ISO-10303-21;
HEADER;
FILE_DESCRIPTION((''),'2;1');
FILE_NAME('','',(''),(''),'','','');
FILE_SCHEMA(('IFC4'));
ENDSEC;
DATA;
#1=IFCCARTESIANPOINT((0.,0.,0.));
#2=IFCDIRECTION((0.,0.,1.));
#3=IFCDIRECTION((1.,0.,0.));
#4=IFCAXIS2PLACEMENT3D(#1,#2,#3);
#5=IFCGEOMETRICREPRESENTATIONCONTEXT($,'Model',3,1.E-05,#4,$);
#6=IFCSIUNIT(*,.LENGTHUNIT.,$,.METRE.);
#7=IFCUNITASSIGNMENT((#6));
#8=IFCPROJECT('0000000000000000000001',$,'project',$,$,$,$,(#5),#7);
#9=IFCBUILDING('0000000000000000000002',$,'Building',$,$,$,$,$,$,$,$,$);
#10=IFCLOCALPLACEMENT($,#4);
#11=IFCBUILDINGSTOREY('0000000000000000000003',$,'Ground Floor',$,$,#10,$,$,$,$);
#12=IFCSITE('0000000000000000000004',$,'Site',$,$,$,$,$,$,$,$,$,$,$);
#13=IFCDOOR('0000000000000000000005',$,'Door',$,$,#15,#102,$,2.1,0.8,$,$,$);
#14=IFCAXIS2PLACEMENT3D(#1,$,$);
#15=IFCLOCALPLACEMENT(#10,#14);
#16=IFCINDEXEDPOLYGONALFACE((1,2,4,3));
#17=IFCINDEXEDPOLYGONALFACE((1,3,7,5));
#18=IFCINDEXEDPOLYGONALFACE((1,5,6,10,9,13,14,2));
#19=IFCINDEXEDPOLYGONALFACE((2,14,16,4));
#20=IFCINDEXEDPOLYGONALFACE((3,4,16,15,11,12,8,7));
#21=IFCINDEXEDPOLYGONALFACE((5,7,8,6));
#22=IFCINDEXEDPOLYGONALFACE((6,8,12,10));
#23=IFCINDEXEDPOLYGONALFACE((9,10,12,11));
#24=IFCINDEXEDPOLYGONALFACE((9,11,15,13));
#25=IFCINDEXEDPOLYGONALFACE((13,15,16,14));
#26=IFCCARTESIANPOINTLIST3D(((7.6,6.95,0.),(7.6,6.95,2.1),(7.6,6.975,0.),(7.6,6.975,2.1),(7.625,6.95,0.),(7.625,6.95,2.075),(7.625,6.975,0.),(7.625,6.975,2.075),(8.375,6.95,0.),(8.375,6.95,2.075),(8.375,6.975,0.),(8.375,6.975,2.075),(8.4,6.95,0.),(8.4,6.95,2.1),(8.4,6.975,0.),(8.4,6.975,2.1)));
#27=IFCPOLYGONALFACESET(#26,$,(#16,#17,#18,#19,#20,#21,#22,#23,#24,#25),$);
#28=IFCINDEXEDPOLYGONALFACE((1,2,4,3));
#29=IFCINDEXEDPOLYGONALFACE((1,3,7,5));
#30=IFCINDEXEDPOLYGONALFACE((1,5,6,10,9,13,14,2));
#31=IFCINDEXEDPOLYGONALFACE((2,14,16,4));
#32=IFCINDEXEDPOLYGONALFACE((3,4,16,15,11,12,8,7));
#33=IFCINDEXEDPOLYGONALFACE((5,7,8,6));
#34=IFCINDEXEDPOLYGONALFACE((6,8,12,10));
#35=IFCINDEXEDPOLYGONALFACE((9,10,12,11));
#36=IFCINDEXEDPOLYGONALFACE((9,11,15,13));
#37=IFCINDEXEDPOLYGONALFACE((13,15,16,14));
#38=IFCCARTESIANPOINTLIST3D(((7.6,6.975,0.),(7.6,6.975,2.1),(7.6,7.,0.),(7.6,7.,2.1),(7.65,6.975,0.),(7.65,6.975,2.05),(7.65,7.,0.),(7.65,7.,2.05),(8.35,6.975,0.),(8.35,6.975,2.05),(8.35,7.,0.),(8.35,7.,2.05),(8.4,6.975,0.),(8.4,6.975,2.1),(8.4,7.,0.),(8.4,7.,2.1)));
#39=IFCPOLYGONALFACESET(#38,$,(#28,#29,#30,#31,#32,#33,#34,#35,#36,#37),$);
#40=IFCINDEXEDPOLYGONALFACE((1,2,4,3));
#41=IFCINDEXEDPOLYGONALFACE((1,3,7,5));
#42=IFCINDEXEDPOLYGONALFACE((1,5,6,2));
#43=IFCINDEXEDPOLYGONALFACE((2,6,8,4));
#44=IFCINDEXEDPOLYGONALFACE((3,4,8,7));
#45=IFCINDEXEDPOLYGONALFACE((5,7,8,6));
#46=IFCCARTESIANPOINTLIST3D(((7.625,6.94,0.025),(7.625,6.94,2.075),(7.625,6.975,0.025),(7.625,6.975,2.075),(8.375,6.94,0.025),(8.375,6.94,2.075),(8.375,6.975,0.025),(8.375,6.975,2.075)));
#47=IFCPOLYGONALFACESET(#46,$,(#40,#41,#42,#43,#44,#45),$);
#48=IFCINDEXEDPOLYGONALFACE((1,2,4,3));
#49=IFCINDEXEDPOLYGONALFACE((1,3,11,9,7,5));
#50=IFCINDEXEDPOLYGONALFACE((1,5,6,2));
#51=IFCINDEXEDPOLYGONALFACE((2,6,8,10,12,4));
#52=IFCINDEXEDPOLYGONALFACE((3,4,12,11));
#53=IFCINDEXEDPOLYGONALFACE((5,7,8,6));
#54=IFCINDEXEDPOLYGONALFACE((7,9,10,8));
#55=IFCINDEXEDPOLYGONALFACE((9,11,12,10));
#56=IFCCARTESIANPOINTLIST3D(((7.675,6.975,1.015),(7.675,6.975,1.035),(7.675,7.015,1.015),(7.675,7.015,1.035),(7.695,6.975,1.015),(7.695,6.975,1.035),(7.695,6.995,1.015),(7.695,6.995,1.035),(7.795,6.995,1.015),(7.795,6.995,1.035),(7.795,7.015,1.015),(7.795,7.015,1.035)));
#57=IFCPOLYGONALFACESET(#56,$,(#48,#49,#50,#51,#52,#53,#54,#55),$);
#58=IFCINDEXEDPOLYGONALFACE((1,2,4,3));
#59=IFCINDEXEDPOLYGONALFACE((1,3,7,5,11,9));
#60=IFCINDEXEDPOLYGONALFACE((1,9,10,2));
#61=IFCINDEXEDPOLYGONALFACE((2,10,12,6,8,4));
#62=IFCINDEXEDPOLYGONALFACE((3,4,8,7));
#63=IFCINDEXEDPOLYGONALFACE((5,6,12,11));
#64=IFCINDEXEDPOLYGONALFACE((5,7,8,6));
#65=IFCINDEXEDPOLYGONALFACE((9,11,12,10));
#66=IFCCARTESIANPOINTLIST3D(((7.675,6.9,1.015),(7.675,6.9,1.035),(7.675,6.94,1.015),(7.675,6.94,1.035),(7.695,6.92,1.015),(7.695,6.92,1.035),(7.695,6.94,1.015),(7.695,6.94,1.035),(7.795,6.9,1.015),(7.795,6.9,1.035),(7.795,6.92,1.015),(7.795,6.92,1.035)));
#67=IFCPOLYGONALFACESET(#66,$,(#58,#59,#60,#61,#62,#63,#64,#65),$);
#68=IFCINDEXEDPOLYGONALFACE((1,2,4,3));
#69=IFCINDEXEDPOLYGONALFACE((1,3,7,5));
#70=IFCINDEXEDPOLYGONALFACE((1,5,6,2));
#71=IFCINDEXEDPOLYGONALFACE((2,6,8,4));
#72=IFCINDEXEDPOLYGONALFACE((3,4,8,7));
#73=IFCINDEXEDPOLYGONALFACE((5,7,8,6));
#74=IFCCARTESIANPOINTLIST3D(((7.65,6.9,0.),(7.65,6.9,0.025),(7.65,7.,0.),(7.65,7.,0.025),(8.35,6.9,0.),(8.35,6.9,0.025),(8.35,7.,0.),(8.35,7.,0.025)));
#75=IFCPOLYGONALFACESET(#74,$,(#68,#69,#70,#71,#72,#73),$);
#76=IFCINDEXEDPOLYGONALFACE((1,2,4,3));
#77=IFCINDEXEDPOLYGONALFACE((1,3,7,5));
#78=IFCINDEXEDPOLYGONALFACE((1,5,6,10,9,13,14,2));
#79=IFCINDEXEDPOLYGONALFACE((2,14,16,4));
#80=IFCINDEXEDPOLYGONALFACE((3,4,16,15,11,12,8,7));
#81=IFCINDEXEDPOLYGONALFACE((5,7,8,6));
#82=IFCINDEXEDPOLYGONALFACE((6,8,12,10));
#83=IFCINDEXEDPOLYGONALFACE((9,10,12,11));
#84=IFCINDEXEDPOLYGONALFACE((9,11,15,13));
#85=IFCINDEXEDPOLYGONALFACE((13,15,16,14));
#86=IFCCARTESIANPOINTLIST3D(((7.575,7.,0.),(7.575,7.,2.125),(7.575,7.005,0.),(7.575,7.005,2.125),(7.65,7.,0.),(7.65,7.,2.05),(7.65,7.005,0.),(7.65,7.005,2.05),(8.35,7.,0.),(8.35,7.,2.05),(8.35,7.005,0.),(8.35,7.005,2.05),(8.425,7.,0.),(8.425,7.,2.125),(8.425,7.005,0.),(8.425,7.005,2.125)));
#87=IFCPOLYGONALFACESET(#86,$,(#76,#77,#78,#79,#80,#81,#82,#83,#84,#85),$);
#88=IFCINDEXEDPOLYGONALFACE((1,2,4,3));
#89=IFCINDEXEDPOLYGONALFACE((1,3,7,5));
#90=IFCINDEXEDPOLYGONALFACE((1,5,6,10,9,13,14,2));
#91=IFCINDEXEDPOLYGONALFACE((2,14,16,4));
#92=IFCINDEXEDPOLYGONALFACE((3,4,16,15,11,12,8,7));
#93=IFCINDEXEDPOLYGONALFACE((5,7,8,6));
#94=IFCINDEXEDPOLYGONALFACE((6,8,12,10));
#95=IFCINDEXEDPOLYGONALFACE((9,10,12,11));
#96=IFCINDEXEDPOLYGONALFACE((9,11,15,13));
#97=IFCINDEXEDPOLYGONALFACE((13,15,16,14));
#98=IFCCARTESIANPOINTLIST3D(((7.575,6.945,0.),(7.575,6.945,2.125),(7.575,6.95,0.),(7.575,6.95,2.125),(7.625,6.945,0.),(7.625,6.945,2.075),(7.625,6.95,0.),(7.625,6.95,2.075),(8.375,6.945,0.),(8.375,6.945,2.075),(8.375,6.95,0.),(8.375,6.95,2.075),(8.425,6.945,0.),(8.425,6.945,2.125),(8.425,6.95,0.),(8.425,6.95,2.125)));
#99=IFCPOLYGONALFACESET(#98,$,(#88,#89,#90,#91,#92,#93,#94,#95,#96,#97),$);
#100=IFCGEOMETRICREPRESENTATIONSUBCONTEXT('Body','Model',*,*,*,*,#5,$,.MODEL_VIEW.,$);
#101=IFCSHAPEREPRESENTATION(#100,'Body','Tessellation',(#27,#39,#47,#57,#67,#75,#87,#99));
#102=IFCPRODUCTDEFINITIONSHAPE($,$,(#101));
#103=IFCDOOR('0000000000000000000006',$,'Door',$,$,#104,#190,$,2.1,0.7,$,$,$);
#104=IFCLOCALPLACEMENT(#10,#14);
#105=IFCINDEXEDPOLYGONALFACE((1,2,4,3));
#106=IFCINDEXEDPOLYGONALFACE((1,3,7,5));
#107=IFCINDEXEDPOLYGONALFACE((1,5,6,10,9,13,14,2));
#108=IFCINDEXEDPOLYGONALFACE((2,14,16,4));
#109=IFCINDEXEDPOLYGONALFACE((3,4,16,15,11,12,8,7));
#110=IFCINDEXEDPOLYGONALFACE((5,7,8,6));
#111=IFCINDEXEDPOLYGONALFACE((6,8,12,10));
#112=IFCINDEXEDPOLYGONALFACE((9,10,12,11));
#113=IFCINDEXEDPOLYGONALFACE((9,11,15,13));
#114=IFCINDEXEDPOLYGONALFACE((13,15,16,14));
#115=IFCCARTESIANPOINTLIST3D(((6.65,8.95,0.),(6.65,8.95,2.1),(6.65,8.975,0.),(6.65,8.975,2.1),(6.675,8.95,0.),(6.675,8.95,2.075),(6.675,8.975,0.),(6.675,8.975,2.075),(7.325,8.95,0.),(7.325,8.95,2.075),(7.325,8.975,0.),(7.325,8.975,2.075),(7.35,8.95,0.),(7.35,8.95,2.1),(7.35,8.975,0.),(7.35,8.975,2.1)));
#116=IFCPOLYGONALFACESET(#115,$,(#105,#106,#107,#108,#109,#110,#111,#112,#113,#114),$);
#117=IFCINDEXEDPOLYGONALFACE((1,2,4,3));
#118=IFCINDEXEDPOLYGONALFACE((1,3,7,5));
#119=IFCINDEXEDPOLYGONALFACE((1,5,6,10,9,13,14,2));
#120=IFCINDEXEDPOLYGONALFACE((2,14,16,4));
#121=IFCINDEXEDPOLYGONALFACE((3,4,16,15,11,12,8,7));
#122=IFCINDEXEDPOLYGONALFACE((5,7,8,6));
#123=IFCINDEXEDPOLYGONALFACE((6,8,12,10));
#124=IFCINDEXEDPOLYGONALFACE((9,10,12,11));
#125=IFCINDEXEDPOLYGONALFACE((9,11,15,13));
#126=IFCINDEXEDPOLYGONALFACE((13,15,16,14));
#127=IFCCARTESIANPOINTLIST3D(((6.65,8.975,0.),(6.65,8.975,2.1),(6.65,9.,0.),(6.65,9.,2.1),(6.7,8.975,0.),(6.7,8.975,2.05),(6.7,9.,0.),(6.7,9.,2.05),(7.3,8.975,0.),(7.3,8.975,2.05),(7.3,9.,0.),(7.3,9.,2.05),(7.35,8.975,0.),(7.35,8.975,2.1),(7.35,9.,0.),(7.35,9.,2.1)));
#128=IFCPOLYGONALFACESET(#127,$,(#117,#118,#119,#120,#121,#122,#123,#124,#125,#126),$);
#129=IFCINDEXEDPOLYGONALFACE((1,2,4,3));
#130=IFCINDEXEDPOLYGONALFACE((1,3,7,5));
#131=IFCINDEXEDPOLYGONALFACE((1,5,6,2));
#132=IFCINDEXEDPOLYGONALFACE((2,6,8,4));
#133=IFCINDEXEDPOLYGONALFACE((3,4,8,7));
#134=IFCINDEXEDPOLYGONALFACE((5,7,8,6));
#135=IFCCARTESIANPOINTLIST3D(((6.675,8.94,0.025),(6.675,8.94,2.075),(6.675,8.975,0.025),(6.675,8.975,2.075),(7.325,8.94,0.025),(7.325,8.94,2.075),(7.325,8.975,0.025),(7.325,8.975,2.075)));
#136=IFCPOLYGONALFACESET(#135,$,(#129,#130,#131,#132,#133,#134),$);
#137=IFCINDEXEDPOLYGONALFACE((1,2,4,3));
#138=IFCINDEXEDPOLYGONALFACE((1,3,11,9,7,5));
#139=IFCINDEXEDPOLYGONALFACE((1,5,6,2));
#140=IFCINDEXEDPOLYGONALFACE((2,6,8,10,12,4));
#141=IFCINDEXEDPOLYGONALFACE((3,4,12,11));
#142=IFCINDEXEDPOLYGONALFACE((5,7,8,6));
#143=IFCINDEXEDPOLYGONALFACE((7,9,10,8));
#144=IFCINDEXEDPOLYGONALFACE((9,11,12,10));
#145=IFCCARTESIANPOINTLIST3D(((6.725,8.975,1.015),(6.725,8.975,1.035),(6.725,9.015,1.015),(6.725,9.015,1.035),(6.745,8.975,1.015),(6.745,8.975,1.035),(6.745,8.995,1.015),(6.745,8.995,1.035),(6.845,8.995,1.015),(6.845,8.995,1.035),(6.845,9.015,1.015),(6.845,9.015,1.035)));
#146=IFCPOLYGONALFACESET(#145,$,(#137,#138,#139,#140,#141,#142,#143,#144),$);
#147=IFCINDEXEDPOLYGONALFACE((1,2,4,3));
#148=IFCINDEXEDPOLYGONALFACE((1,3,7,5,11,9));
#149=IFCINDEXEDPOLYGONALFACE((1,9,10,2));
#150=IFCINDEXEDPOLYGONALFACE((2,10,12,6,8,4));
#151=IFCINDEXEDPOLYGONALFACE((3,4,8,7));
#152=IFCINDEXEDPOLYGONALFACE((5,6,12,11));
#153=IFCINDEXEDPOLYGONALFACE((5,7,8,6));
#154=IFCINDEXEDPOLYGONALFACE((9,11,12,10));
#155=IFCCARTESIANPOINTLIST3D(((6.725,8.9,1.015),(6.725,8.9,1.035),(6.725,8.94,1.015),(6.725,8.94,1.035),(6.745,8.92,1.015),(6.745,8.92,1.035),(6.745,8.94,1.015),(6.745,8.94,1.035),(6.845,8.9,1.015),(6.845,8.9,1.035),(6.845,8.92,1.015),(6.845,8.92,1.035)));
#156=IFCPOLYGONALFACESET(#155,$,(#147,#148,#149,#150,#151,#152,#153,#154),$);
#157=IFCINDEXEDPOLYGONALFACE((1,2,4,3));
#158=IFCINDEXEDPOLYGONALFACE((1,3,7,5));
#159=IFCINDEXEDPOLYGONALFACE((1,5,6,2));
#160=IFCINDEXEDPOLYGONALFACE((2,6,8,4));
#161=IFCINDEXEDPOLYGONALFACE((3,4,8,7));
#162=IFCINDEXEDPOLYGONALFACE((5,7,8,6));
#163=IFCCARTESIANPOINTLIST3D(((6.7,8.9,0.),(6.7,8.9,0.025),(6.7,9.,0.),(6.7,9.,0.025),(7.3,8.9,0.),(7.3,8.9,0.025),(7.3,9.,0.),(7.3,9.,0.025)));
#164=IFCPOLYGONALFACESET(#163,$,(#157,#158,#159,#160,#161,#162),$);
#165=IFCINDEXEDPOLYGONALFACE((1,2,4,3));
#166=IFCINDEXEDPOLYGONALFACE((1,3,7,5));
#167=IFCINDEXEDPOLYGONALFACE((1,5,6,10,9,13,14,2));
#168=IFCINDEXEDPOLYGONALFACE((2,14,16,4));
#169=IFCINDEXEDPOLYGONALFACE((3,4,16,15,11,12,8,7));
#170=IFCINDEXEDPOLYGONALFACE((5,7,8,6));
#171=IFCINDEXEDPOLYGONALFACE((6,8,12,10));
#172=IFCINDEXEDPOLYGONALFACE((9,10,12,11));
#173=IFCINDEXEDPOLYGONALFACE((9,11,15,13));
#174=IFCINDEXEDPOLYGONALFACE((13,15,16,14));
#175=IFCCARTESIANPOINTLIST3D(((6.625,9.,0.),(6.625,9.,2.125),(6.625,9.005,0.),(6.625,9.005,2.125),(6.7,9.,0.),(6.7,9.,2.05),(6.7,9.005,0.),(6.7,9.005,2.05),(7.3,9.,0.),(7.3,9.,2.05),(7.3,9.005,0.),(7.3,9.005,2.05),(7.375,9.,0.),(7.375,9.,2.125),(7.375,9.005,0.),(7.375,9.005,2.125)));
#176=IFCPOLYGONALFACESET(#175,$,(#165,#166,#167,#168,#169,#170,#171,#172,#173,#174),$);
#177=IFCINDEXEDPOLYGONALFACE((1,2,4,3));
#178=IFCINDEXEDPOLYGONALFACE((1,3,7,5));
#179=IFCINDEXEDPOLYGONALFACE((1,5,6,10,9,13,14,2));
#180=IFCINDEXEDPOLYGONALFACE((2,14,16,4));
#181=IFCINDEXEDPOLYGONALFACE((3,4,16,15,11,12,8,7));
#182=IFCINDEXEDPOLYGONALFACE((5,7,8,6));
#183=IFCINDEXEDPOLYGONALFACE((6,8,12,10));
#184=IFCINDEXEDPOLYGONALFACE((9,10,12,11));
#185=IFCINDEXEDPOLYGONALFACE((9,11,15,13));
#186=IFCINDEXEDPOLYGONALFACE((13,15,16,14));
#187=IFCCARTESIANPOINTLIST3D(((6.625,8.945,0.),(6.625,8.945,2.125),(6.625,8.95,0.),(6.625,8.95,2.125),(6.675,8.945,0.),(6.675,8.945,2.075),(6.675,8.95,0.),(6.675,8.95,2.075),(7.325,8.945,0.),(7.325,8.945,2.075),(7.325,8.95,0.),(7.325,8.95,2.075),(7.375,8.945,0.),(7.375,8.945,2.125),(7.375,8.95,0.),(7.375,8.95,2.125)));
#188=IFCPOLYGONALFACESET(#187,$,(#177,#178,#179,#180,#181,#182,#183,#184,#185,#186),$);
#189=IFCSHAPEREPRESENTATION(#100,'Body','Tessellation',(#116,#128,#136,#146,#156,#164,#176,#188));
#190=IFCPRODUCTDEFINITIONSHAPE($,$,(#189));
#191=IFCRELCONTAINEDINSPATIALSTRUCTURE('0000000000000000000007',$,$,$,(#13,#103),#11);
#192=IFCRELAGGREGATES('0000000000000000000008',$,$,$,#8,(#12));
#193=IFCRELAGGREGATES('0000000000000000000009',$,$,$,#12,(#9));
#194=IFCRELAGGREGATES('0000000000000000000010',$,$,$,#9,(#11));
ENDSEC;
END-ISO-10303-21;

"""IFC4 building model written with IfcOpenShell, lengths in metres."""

from ifc_helpers import new_model, si_unit, frame, origin_with_axes, place, context, subcontext, project, spatial, line, indexed_curve, outline, extrude, element, save


model = new_model("IFC4")

# Units and contexts
model_context = context("Model", 3, precision=1e-05, world=origin_with_axes())
body_context = subcontext(model_context, "Body", "Model", "MODEL_VIEW")
ifc_project = project(units=[si_unit("LENGTHUNIT", "METRE")], contexts=[model_context])

# Site, building, storey
site = spatial("IfcSite", under=ifc_project, Name="Site")
building = spatial("IfcBuilding", under=site, Name="Building")
storey_placement = place(None, origin_with_axes())
storey = spatial("IfcBuildingStorey", under=building, at=storey_placement, Name="Ground Floor")

# Doors
door_1_placement = place(storey_placement, frame((8.4, 7.0, 0.0), z_axis=(0.0, 0.0, 1.0), x_axis=(-1.0, 0.0, 0.0)))
element("IfcDoor", 1, at=door_1_placement, inside=storey, Name="Door", OverallHeight=2.1, OverallWidth=0.8, context=body_context, shape_type="SweptSolid", body=[
    extrude(outline(indexed_curve([(0.0, 0.0), (0.0, 2.1), (0.8, 2.1), (0.8, 0.0), (0.775, 0.0), (0.775, 2.075), (0.025, 2.075), (0.025, 0.0)], segments=[line(1, 2, 3, 4, 5, 6, 7, 8, 1)])), frame((0.0, 0.025, 0.0), z_axis=(0.0, -1.0, 0.0), x_axis=(1.0, 0.0, 0.0)), (0.0, 0.0, -1.0), 0.025),
    extrude(outline(indexed_curve([(0.0, 0.0), (0.0, 2.1), (0.8, 2.1), (0.8, 0.0), (0.75, 0.0), (0.75, 2.05), (0.05, 2.05), (0.05, 0.0)], segments=[line(1, 2, 3, 4, 5, 6, 7, 8, 1)])), frame((0.0, 0.0, 0.0), z_axis=(0.0, -1.0, 0.0), x_axis=(1.0, 0.0, 0.0)), (0.0, 0.0, -1.0), 0.025),
    extrude(outline(indexed_curve([(0.0, 0.0), (0.75, 0.0), (0.75, 0.035), (0.0, 0.035)], segments=[line(1, 2, 3, 4, 1)])), frame((0.025, 0.025, 0.025), z_axis=(0.0, 0.0, 1.0), x_axis=(1.0, 0.0, 0.0)), (0.0, 0.0, 1.0), 2.05),
    extrude(outline(indexed_curve([(0.0, 0.0), (0.0, -0.04), (-0.12, -0.04), (-0.12, -0.02), (-0.02, -0.02), (-0.02, 0.0)], segments=[line(1, 2, 3, 4, 5, 6, 1)])), frame((0.725, 0.025, 1.015), z_axis=(0.0, 0.0, 1.0), x_axis=(1.0, 0.0, 0.0)), (0.0, 0.0, 1.0), 0.02),
    extrude(outline(indexed_curve([(0.0, 0.0), (0.0, 0.04), (-0.12, 0.04), (-0.12, 0.02), (-0.02, 0.02), (-0.02, 0.0)], segments=[line(1, 2, 3, 4, 5, 6, 1)])), frame((0.725, 0.06, 1.015), z_axis=(0.0, 0.0, 1.0), x_axis=(1.0, 0.0, 0.0)), (0.0, 0.0, 1.0), 0.02),
    extrude(outline(indexed_curve([(0.0, 0.0), (0.7, 0.0), (0.7, 0.1), (0.0, 0.1)], segments=[line(1, 2, 3, 4, 1)])), frame((0.05, 0.0, 0.0), z_axis=(0.0, 0.0, 1.0), x_axis=(1.0, 0.0, 0.0)), (0.0, 0.0, 1.0), 0.025),
    extrude(outline(indexed_curve([(0.0, 0.0), (0.0, 2.125), (0.85, 2.125), (0.85, 0.0), (0.775, 0.0), (0.775, 2.05), (0.075, 2.05), (0.075, 0.0)], segments=[line(1, 2, 3, 4, 5, 6, 7, 8, 1)])), frame((-0.025, -0.005, 0.0), z_axis=(0.0, -1.0, 0.0), x_axis=(1.0, 0.0, 0.0)), (0.0, 0.0, -1.0), 0.005),
    extrude(outline(indexed_curve([(0.0, 0.0), (0.0, 2.125), (0.85, 2.125), (0.85, 0.0), (0.8, 0.0), (0.8, 2.075), (0.05, 2.075), (0.05, 0.0)], segments=[line(1, 2, 3, 4, 5, 6, 7, 8, 1)])), frame((-0.025, 0.05, 0.0), z_axis=(0.0, -1.0, 0.0), x_axis=(1.0, 0.0, 0.0)), (0.0, 0.0, -1.0), 0.005),
])
door_2_placement = place(storey_placement, frame((7.35, 9.0, 0.0), z_axis=(0.0, 0.0, 1.0), x_axis=(-1.0, 0.0, 0.0)))
element("IfcDoor", 2, at=door_2_placement, inside=storey, Name="Door", OverallHeight=2.1, OverallWidth=0.7, context=body_context, shape_type="SweptSolid", body=[
    extrude(outline(indexed_curve([(0.0, 0.0), (0.0, 2.1), (0.7, 2.1), (0.7, 0.0), (0.675, 0.0), (0.675, 2.075), (0.025, 2.075), (0.025, 0.0)], segments=[line(1, 2, 3, 4, 5, 6, 7, 8, 1)])), frame((0.0, 0.025, 0.0), z_axis=(0.0, -1.0, 0.0), x_axis=(1.0, 0.0, 0.0)), (0.0, 0.0, -1.0), 0.025),
    extrude(outline(indexed_curve([(0.0, 0.0), (0.0, 2.1), (0.7, 2.1), (0.7, 0.0), (0.65, 0.0), (0.65, 2.05), (0.05, 2.05), (0.05, 0.0)], segments=[line(1, 2, 3, 4, 5, 6, 7, 8, 1)])), frame((0.0, 0.0, 0.0), z_axis=(0.0, -1.0, 0.0), x_axis=(1.0, 0.0, 0.0)), (0.0, 0.0, -1.0), 0.025),
    extrude(outline(indexed_curve([(0.0, 0.0), (0.65, 0.0), (0.65, 0.035), (0.0, 0.035)], segments=[line(1, 2, 3, 4, 1)])), frame((0.025, 0.025, 0.025), z_axis=(0.0, 0.0, 1.0), x_axis=(1.0, 0.0, 0.0)), (0.0, 0.0, 1.0), 2.05),
    extrude(outline(indexed_curve([(0.0, 0.0), (0.0, -0.04), (-0.12, -0.04), (-0.12, -0.02), (-0.02, -0.02), (-0.02, 0.0)], segments=[line(1, 2, 3, 4, 5, 6, 1)])), frame((0.625, 0.025, 1.015), z_axis=(0.0, 0.0, 1.0), x_axis=(1.0, 0.0, 0.0)), (0.0, 0.0, 1.0), 0.02),
    extrude(outline(indexed_curve([(0.0, 0.0), (0.0, 0.04), (-0.12, 0.04), (-0.12, 0.02), (-0.02, 0.02), (-0.02, 0.0)], segments=[line(1, 2, 3, 4, 5, 6, 1)])), frame((0.625, 0.06, 1.015), z_axis=(0.0, 0.0, 1.0), x_axis=(1.0, 0.0, 0.0)), (0.0, 0.0, 1.0), 0.02),
    extrude(outline(indexed_curve([(0.0, 0.0), (0.6, 0.0), (0.6, 0.1), (0.0, 0.1)], segments=[line(1, 2, 3, 4, 1)])), frame((0.05, 0.0, 0.0), z_axis=(0.0, 0.0, 1.0), x_axis=(1.0, 0.0, 0.0)), (0.0, 0.0, 1.0), 0.025),
    extrude(outline(indexed_curve([(0.0, 0.0), (0.0, 2.125), (0.75, 2.125), (0.75, 0.0), (0.675, 0.0), (0.675, 2.05), (0.075, 2.05), (0.075, 0.0)], segments=[line(1, 2, 3, 4, 5, 6, 7, 8, 1)])), frame((-0.025, -0.005, 0.0), z_axis=(0.0, -1.0, 0.0), x_axis=(1.0, 0.0, 0.0)), (0.0, 0.0, -1.0), 0.005),
    extrude(outline(indexed_curve([(0.0, 0.0), (0.0, 2.125), (0.75, 2.125), (0.75, 0.0), (0.7, 0.0), (0.7, 2.075), (0.05, 2.075), (0.05, 0.0)], segments=[line(1, 2, 3, 4, 5, 6, 7, 8, 1)])), frame((-0.025, 0.05, 0.0), z_axis=(0.0, -1.0, 0.0), x_axis=(1.0, 0.0, 0.0)), (0.0, 0.0, -1.0), 0.005),
])

save(model, "model.ifc")
